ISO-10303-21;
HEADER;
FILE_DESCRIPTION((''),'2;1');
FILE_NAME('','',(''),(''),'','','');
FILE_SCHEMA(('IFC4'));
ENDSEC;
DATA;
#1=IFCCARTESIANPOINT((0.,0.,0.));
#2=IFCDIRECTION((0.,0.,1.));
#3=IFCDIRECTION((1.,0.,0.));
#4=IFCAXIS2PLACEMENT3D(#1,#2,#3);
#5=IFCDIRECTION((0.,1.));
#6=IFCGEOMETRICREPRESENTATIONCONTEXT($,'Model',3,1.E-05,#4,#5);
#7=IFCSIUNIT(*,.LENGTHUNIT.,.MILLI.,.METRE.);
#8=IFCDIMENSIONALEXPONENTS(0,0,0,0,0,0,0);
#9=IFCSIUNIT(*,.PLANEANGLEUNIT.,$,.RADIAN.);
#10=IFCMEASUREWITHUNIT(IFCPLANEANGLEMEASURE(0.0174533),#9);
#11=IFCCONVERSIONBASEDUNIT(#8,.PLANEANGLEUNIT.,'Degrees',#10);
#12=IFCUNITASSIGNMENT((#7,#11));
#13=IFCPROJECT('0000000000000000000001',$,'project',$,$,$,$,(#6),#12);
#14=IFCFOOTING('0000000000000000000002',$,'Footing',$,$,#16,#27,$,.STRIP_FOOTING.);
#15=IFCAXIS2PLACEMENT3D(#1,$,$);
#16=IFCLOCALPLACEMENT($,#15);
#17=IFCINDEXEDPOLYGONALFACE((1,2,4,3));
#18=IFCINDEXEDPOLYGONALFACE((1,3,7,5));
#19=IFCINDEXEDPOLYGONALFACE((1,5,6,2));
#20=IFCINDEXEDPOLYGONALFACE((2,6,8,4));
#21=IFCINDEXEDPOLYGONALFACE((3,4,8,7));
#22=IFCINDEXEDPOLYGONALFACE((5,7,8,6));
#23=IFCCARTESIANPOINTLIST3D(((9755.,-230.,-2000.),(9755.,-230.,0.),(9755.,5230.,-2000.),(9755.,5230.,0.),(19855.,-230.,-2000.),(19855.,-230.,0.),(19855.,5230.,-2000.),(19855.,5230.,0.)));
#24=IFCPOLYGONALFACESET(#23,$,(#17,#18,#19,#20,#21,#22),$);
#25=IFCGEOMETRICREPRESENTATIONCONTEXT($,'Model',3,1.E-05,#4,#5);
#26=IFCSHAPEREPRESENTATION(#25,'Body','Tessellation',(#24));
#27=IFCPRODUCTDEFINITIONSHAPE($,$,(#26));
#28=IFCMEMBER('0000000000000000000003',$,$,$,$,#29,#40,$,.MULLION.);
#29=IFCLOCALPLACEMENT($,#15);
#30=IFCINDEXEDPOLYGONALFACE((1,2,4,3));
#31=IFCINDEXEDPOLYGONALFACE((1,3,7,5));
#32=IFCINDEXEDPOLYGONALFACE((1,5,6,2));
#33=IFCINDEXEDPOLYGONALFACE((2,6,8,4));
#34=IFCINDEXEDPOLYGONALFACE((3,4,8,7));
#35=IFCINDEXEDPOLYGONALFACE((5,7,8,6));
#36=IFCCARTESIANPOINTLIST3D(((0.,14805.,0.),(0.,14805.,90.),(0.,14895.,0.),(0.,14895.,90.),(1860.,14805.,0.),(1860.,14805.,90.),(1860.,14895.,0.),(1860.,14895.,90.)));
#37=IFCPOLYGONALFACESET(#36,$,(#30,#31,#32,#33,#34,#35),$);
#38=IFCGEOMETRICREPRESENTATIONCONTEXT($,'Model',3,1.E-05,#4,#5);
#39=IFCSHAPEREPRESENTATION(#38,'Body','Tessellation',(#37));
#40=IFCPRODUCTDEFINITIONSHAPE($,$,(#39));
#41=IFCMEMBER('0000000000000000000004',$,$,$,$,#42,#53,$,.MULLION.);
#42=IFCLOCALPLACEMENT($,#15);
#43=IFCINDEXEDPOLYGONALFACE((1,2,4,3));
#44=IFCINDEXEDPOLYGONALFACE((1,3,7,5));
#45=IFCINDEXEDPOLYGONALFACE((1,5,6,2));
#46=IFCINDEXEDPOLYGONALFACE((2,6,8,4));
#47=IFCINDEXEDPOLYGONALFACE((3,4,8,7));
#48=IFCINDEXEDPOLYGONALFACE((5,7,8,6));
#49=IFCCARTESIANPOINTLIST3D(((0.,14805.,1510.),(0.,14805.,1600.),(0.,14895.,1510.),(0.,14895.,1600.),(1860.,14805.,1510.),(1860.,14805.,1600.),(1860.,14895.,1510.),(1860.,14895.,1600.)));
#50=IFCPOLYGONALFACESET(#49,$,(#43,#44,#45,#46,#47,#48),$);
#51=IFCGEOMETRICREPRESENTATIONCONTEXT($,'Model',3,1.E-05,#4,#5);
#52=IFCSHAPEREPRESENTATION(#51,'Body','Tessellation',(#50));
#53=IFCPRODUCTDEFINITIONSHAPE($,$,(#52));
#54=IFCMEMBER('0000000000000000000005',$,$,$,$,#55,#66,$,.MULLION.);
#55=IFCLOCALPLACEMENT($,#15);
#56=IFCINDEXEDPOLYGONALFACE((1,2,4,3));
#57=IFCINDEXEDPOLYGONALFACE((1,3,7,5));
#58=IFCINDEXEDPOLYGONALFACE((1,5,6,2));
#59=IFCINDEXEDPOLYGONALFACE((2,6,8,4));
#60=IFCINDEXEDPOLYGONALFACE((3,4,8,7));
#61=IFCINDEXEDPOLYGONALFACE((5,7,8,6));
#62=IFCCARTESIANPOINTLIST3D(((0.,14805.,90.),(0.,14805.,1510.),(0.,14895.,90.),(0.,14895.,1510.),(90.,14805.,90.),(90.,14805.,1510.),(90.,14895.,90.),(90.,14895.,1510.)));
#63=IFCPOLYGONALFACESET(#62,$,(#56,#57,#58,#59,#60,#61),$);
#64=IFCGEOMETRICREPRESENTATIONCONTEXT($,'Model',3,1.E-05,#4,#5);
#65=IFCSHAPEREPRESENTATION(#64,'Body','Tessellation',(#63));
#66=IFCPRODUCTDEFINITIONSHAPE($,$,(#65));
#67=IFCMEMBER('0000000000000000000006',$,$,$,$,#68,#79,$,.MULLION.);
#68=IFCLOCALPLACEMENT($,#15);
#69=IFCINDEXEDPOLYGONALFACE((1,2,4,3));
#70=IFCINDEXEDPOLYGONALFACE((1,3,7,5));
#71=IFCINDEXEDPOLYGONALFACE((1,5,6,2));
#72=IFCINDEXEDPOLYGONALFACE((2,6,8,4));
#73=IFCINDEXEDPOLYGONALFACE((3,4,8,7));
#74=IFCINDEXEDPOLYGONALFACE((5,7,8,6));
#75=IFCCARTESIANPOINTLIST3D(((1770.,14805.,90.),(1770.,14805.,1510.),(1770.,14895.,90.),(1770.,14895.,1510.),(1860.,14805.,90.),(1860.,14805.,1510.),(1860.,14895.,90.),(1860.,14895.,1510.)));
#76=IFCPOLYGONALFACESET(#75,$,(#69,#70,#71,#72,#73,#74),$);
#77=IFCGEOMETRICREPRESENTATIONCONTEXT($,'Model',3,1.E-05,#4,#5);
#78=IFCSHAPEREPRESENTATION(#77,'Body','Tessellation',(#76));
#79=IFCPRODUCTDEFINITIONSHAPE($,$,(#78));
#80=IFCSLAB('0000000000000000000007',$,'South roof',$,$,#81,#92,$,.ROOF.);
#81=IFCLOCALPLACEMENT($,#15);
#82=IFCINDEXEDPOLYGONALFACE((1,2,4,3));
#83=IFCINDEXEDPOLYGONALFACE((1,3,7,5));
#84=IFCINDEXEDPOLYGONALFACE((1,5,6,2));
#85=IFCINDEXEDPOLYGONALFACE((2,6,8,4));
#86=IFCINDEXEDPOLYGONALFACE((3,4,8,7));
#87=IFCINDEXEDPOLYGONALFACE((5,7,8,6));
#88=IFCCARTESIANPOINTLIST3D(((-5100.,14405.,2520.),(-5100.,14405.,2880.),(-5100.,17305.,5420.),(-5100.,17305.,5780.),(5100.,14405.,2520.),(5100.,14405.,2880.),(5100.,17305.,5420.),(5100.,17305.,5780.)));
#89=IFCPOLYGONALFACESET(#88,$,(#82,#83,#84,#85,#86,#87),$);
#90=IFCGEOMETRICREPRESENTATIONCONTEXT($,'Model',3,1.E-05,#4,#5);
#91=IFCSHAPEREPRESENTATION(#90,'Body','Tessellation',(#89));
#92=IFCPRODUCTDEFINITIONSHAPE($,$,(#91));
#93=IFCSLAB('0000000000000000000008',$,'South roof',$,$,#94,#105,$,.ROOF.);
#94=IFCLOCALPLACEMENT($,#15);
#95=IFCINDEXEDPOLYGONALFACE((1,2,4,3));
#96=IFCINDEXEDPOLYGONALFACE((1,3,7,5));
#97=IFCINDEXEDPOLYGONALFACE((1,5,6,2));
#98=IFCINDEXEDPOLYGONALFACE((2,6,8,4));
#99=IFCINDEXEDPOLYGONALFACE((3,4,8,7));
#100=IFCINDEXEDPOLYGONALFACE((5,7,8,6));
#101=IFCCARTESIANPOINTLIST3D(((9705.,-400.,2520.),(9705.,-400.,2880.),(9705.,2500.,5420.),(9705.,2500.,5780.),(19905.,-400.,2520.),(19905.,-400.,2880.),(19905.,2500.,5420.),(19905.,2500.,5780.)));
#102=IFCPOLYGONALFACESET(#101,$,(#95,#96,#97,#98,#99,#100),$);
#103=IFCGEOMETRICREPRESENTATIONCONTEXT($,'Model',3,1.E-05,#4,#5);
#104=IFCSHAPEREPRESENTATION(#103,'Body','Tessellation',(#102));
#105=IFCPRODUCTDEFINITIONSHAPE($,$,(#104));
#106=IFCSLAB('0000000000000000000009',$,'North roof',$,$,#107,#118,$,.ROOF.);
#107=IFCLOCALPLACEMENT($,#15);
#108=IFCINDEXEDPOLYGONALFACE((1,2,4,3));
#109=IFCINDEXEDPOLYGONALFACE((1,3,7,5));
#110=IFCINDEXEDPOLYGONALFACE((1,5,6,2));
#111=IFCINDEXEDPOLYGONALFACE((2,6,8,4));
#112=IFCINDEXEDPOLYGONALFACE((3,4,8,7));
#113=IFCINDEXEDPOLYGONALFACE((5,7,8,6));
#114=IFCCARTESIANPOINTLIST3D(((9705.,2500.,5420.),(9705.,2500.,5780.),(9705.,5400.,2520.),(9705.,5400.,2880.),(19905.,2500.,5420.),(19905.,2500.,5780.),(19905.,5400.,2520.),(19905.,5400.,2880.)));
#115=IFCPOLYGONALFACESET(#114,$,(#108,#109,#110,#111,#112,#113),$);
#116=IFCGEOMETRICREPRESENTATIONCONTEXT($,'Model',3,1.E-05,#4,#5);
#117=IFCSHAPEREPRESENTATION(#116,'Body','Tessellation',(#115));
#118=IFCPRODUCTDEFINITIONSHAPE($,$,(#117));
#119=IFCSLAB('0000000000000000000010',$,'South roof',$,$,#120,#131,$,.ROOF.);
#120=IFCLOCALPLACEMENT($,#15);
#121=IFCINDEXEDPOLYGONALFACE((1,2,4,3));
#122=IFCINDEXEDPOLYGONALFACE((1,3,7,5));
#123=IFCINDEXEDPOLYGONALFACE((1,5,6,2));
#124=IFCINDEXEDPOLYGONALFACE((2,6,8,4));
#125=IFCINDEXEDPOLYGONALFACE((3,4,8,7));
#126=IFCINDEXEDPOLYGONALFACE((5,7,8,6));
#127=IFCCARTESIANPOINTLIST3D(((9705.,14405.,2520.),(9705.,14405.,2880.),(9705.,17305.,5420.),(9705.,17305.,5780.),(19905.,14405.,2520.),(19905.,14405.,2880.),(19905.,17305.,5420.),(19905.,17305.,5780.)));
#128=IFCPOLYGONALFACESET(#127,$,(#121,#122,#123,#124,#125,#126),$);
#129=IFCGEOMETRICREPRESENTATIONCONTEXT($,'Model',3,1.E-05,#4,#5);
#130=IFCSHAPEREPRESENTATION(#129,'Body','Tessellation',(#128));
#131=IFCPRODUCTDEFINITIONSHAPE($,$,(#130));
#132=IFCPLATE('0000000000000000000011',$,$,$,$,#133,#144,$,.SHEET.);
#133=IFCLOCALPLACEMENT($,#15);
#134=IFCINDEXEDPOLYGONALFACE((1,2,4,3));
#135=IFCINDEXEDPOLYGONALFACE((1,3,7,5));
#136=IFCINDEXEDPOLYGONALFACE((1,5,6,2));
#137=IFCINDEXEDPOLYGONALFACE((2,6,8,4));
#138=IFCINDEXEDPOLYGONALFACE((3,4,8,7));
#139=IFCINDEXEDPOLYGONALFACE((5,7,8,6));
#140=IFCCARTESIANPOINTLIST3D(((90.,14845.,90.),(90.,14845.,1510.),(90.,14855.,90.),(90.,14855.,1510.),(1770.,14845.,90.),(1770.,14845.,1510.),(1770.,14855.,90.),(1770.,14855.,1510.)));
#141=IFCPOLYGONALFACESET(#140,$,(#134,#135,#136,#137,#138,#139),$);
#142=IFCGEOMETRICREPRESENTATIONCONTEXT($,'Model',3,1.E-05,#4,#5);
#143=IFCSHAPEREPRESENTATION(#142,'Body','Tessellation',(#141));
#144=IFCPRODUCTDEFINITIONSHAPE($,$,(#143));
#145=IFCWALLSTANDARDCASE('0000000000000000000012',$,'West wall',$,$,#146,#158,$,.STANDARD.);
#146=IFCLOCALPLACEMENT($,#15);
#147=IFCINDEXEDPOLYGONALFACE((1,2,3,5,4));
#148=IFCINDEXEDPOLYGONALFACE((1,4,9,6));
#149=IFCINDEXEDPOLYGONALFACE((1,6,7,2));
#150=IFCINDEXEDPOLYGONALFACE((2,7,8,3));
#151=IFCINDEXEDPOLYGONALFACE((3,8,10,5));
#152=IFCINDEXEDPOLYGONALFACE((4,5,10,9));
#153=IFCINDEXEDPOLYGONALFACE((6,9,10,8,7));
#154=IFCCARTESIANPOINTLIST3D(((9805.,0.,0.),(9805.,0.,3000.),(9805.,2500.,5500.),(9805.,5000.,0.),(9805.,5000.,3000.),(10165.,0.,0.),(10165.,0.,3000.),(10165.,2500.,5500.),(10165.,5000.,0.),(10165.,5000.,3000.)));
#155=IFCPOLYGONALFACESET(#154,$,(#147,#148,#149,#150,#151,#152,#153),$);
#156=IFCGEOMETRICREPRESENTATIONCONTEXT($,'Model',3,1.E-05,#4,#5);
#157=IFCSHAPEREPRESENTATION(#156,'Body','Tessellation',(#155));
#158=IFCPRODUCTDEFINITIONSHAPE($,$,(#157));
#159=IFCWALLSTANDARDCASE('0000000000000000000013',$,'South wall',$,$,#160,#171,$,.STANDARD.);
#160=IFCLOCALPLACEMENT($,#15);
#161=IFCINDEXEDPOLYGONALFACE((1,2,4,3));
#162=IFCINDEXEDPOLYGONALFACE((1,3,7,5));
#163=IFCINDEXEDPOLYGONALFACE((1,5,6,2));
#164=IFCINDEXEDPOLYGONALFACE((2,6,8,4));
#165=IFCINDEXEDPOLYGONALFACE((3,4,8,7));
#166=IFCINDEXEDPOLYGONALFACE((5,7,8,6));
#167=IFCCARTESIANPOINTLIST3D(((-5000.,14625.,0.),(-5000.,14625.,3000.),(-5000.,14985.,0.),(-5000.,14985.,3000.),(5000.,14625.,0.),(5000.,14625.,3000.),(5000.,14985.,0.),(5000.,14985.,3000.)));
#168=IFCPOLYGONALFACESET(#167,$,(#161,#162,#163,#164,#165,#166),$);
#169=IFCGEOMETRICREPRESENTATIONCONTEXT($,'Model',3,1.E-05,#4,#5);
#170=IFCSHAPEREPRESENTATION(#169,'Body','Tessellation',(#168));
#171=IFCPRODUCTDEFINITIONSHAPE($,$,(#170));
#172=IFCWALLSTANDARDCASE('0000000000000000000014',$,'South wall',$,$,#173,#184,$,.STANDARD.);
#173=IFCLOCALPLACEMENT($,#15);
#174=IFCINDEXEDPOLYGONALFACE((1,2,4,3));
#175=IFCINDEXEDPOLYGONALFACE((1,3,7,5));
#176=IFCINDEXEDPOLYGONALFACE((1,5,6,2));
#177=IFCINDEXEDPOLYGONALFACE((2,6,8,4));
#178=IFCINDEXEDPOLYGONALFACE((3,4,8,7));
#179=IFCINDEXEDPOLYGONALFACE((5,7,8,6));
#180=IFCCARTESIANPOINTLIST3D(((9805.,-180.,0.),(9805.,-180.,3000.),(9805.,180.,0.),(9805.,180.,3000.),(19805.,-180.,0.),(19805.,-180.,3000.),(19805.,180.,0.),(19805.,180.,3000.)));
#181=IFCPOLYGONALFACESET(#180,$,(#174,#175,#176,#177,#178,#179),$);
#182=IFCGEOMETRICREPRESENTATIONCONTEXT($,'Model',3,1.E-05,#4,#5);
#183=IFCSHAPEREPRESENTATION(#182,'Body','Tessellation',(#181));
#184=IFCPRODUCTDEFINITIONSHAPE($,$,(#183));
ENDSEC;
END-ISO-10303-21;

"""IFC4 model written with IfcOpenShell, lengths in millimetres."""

from ifc_helpers import new_model, entity, si_unit, converted_unit, direction, frame, origin_with_axes, place, context, project, polyline, outline, extrude, clip, halfspace, source, transform, mapped, element, save


model = new_model("IFC4")

# Units and contexts
model_context_1 = context("Model", 3, precision=1e-05, world=origin_with_axes(), true_north=direction((0.0, 1.0)))
model_context_2 = context("Model", 3, precision=1e-05, world=origin_with_axes(), true_north=direction((0.0, 1.0)))
model_context_3 = context("Model", 3, precision=1e-05, world=origin_with_axes(), true_north=direction((0.0, 1.0)))
model_context_4 = context("Model", 3, precision=1e-05, world=origin_with_axes(), true_north=direction((0.0, 1.0)))
model_context_5 = context("Model", 3, precision=1e-05, world=origin_with_axes(), true_north=direction((0.0, 1.0)))
model_context_6 = context("Model", 3, precision=1e-05, world=origin_with_axes(), true_north=direction((0.0, 1.0)))
model_context_7 = context("Model", 3, precision=1e-05, world=origin_with_axes(), true_north=direction((0.0, 1.0)))
model_context_8 = context("Model", 3, precision=1e-05, world=origin_with_axes(), true_north=direction((0.0, 1.0)))
model_context_9 = context("Model", 3, precision=1e-05, world=origin_with_axes(), true_north=direction((0.0, 1.0)))
model_context_10 = context("Model", 3, precision=1e-05, world=origin_with_axes(), true_north=direction((0.0, 1.0)))
model_context_11 = context("Model", 3, precision=1e-05, world=origin_with_axes(), true_north=direction((0.0, 1.0)))
model_context_12 = context("Model", 3, precision=1e-05, world=origin_with_axes(), true_north=direction((0.0, 1.0)))
model_context_13 = context("Model", 3, precision=1e-05, world=origin_with_axes(), true_north=direction((0.0, 1.0)))
model_context_14 = context("Model", 3, precision=1e-05, world=origin_with_axes(), true_north=direction((0.0, 1.0)))
ifc_project = project(units=[si_unit("LENGTHUNIT", "METRE", prefix="MILLI"), converted_unit("PLANEANGLEUNIT", "Degrees", entity("IfcPlaneAngleMeasure", 0.0174533), si_unit("PLANEANGLEUNIT", "RADIAN"), dimensions=[0, 0, 0, 0, 0, 0, 0])], contexts=[model_context_1])

# Footing
placement_1 = place(None, frame((14805.0, 0.0, 0.0)))
footing_placement = place(placement_1, frame((0.0, 2500.0, -2000.0), z_axis=(0.0, 0.0, 1.0), x_axis=(1.0, 0.0, 0.0)))
element("IfcFooting", 1, at=footing_placement, Name="Footing", PredefinedType="STRIP_FOOTING", context=model_context_9, shape_type="SweptSolid", body=[
    extrude(outline(polyline([(-5050.0, -2730.0), (5050.0, -2730.0), (5050.0, 2730.0), (-5050.0, 2730.0), (-5050.0, -2730.0), (-5050.0, -2730.0)])), origin_with_axes(), (0.0, 0.0, 1.0), 2000.0),
])

# Members
shared_shape_1 = source(origin_with_axes(), model_context_2, "Body", "SweptSolid", [
    extrude(outline(polyline([(-930.0, -45.0), (930.0, -45.0), (930.0, 45.0), (-930.0, 45.0), (-930.0, -45.0), (-930.0, -45.0)])), origin_with_axes(), (0.0, 0.0, 1.0), 90.0),
])
placement_2 = place(None, frame((0.0, 14805.0, 0.0)))
member_1_placement = place(placement_2, frame((930.0, 45.0, 0.0), z_axis=(0.0, 0.0, 1.0), x_axis=(1.0, 0.0, 0.0)))
element("IfcMember", 2, at=member_1_placement, PredefinedType="MULLION", context=model_context_2, shape_type="MappedRepresentation", body=[
    mapped(shared_shape_1, transform((0.0, 0.0, 0.0))),
])
shared_shape_2 = source(origin_with_axes(), model_context_3, "Body", "SweptSolid", [
    extrude(outline(polyline([(-930.0, -45.0), (930.0, -45.0), (930.0, 45.0), (-930.0, 45.0), (-930.0, -45.0), (-930.0, -45.0)])), origin_with_axes(), (0.0, 0.0, 1.0), 90.0),
])
member_2_placement = place(placement_2, frame((930.0, 45.0, 1510.0), z_axis=(0.0, 0.0, 1.0), x_axis=(1.0, 0.0, 0.0)))
element("IfcMember", 3, at=member_2_placement, PredefinedType="MULLION", context=model_context_3, shape_type="MappedRepresentation", body=[
    mapped(shared_shape_2, transform((0.0, 0.0, 0.0))),
])
shared_shape_3 = source(origin_with_axes(), model_context_4, "Body", "SweptSolid", [
    extrude(outline(polyline([(-45.0, -45.0), (45.0, -45.0), (45.0, 45.0), (-45.0, 45.0), (-45.0, -45.0), (-45.0, -45.0)])), origin_with_axes(), (0.0, 0.0, 1.0), 1420.0),
])
member_3_placement = place(placement_2, frame((45.0, 45.0, 90.0), z_axis=(0.0, 0.0, 1.0), x_axis=(1.0, 0.0, 0.0)))
element("IfcMember", 4, at=member_3_placement, PredefinedType="MULLION", context=model_context_4, shape_type="MappedRepresentation", body=[
    mapped(shared_shape_3, transform((0.0, 0.0, 0.0))),
])
shared_shape_4 = source(origin_with_axes(), model_context_5, "Body", "SweptSolid", [
    extrude(outline(polyline([(-45.0, -45.0), (45.0, -45.0), (45.0, 45.0), (-45.0, 45.0), (-45.0, -45.0), (-45.0, -45.0)])), origin_with_axes(), (0.0, 0.0, 1.0), 1420.0),
])
member_4_placement = place(placement_2, frame((1815.0, 45.0, 90.0), z_axis=(0.0, 0.0, 1.0), x_axis=(1.0, 0.0, 0.0)))
element("IfcMember", 5, at=member_4_placement, PredefinedType="MULLION", context=model_context_5, shape_type="MappedRepresentation", body=[
    mapped(shared_shape_4, transform((0.0, 0.0, 0.0))),
])

# Slabs
shared_shape_5 = source(origin_with_axes(), model_context_7, "Body", "SweptSolid", [
    extrude(outline(polyline([(-5100.0, -180.0), (5100.0, -180.0), (5100.0, 180.0), (-5100.0, 180.0), (-5100.0, -180.0), (-5100.0, -180.0)])), frame((0.0, 0.0, 0.0), z_axis=(0.0, 1.0, 0.0), x_axis=(1.0, 0.0, 0.0)), (0.0, -0.707107, 0.707107), 4101.2),
])
slab_1_placement = place(placement_2, frame((0.0, -400.0, 2700.0), z_axis=(0.0, 0.0, 1.0), x_axis=(1.0, 0.0, 0.0)))
element("IfcSlab", 6, at=slab_1_placement, Name="South roof", PredefinedType="ROOF", context=model_context_7, shape_type="MappedRepresentation", body=[
    mapped(shared_shape_5, transform((0.0, 0.0, 0.0))),
])
shared_shape_6 = source(origin_with_axes(), model_context_10, "Body", "SweptSolid", [
    extrude(outline(polyline([(-5100.0, -180.0), (5100.0, -180.0), (5100.0, 180.0), (-5100.0, 180.0), (-5100.0, -180.0), (-5100.0, -180.0)])), frame((0.0, 0.0, 0.0), z_axis=(0.0, 1.0, 0.0), x_axis=(1.0, 0.0, 0.0)), (0.0, -0.707107, 0.707107), 4101.2),
])
slab_2_placement = place(placement_1, frame((0.0, -400.0, 2700.0), z_axis=(0.0, 0.0, 1.0), x_axis=(1.0, 0.0, 0.0)))
element("IfcSlab", 7, at=slab_2_placement, Name="South roof", PredefinedType="ROOF", context=model_context_10, shape_type="MappedRepresentation", body=[
    mapped(shared_shape_6, transform((0.0, 0.0, 0.0))),
])
shared_shape_7 = source(origin_with_axes(), model_context_11, "Body", "SweptSolid", [
    extrude(outline(polyline([(-5100.0, -180.0), (5100.0, -180.0), (5100.0, 180.0), (-5100.0, 180.0), (-5100.0, -180.0), (-5100.0, -180.0)])), frame((0.0, 0.0, 0.0), z_axis=(0.0, 1.0, 0.0), x_axis=(1.0, 0.0, 0.0)), (0.0, -0.707107, 0.707107), 4101.2),
])
slab_3_placement = place(placement_1, frame((0.0, 5400.0, 2700.0), z_axis=(0.0, 0.0, 1.0), x_axis=(-1.0, 0.0, 0.0)))
element("IfcSlab", 8, at=slab_3_placement, Name="North roof", PredefinedType="ROOF", context=model_context_11, shape_type="MappedRepresentation", body=[
    mapped(shared_shape_7, transform((0.0, 0.0, 0.0))),
])
shared_shape_8 = source(origin_with_axes(), model_context_14, "Body", "SweptSolid", [
    extrude(outline(polyline([(-5100.0, -180.0), (5100.0, -180.0), (5100.0, 180.0), (-5100.0, 180.0), (-5100.0, -180.0), (-5100.0, -180.0)])), frame((0.0, 0.0, 0.0), z_axis=(0.0, 1.0, 0.0), x_axis=(1.0, 0.0, 0.0)), (0.0, -0.707107, 0.707107), 4101.2),
])
placement_3 = place(None, frame((14805.0, 14805.0, 0.0)))
slab_4_placement = place(placement_3, frame((0.0, -400.0, 2700.0), z_axis=(0.0, 0.0, 1.0), x_axis=(1.0, 0.0, 0.0)))
element("IfcSlab", 9, at=slab_4_placement, Name="South roof", PredefinedType="ROOF", context=model_context_14, shape_type="MappedRepresentation", body=[
    mapped(shared_shape_8, transform((0.0, 0.0, 0.0))),
])

# Plate
plate_1_placement = place(placement_2, frame((930.0, 45.0, 90.0), z_axis=(0.0, 0.0, 1.0), x_axis=(1.0, 0.0, 0.0)))
element("IfcPlate", 10, at=plate_1_placement, PredefinedType="SHEET", context=model_context_6, shape_type="SweptSolid", body=[
    extrude(outline(polyline([(-840.0, -5.0), (840.0, -5.0), (840.0, 5.0), (-840.0, 5.0), (-840.0, -5.0), (-840.0, -5.0)])), origin_with_axes(), (0.0, 0.0, 1.0), 1420.0),
])

# Walls
shared_shape_9 = source(origin_with_axes(), model_context_13, "Body", "Clipping", [
    clip(clip(extrude(outline(polyline([(-2500.0, -180.0), (2500.0, -180.0), (2500.0, 180.0), (-2500.0, 180.0), (-2500.0, -180.0), (-2500.0, -180.0)])), origin_with_axes(), (0.0, 0.0, 1.0), 6000.0), halfspace(frame((-2500.0, 0.0, 3000.0), z_axis=(-1.0, 0.0, 1.0), x_axis=(1.0, 0.0, 0.0)), False)), halfspace(frame((2500.0, 0.0, 3000.0), z_axis=(1.0, 0.0, 1.0), x_axis=(1.0, 0.0, 0.0)), False)),
])
wall_1_placement = place(placement_1, frame((-4820.0, 2500.0, 0.0), z_axis=(0.0, 0.0, 1.0), x_axis=(0.0, -1.0, 0.0)))
element("IfcWallStandardCase", 11, at=wall_1_placement, Name="West wall", PredefinedType="STANDARD", context=model_context_13, shape_type="MappedRepresentation", body=[
    mapped(shared_shape_9, transform((0.0, 0.0, 0.0))),
])
wall_2_placement = place(placement_2, origin_with_axes())
element("IfcWallStandardCase", 12, at=wall_2_placement, Name="South wall", PredefinedType="STANDARD", context=model_context_8, shape_type="SweptSolid", body=[
    extrude(outline(polyline([(-5000.0, -180.0), (5000.0, -180.0), (5000.0, 180.0), (-5000.0, 180.0), (-5000.0, -180.0), (-5000.0, -180.0)])), origin_with_axes(), (0.0, 0.0, 1.0), 3000.0),
])
wall_3_placement = place(placement_1, origin_with_axes())
element("IfcWallStandardCase", 13, at=wall_3_placement, Name="South wall", PredefinedType="STANDARD", context=model_context_12, shape_type="SweptSolid", body=[
    extrude(outline(polyline([(-5000.0, -180.0), (5000.0, -180.0), (5000.0, 180.0), (-5000.0, 180.0), (-5000.0, -180.0), (-5000.0, -180.0)])), origin_with_axes(), (0.0, 0.0, 1.0), 3000.0),
])

save(model, "model.ifc")
